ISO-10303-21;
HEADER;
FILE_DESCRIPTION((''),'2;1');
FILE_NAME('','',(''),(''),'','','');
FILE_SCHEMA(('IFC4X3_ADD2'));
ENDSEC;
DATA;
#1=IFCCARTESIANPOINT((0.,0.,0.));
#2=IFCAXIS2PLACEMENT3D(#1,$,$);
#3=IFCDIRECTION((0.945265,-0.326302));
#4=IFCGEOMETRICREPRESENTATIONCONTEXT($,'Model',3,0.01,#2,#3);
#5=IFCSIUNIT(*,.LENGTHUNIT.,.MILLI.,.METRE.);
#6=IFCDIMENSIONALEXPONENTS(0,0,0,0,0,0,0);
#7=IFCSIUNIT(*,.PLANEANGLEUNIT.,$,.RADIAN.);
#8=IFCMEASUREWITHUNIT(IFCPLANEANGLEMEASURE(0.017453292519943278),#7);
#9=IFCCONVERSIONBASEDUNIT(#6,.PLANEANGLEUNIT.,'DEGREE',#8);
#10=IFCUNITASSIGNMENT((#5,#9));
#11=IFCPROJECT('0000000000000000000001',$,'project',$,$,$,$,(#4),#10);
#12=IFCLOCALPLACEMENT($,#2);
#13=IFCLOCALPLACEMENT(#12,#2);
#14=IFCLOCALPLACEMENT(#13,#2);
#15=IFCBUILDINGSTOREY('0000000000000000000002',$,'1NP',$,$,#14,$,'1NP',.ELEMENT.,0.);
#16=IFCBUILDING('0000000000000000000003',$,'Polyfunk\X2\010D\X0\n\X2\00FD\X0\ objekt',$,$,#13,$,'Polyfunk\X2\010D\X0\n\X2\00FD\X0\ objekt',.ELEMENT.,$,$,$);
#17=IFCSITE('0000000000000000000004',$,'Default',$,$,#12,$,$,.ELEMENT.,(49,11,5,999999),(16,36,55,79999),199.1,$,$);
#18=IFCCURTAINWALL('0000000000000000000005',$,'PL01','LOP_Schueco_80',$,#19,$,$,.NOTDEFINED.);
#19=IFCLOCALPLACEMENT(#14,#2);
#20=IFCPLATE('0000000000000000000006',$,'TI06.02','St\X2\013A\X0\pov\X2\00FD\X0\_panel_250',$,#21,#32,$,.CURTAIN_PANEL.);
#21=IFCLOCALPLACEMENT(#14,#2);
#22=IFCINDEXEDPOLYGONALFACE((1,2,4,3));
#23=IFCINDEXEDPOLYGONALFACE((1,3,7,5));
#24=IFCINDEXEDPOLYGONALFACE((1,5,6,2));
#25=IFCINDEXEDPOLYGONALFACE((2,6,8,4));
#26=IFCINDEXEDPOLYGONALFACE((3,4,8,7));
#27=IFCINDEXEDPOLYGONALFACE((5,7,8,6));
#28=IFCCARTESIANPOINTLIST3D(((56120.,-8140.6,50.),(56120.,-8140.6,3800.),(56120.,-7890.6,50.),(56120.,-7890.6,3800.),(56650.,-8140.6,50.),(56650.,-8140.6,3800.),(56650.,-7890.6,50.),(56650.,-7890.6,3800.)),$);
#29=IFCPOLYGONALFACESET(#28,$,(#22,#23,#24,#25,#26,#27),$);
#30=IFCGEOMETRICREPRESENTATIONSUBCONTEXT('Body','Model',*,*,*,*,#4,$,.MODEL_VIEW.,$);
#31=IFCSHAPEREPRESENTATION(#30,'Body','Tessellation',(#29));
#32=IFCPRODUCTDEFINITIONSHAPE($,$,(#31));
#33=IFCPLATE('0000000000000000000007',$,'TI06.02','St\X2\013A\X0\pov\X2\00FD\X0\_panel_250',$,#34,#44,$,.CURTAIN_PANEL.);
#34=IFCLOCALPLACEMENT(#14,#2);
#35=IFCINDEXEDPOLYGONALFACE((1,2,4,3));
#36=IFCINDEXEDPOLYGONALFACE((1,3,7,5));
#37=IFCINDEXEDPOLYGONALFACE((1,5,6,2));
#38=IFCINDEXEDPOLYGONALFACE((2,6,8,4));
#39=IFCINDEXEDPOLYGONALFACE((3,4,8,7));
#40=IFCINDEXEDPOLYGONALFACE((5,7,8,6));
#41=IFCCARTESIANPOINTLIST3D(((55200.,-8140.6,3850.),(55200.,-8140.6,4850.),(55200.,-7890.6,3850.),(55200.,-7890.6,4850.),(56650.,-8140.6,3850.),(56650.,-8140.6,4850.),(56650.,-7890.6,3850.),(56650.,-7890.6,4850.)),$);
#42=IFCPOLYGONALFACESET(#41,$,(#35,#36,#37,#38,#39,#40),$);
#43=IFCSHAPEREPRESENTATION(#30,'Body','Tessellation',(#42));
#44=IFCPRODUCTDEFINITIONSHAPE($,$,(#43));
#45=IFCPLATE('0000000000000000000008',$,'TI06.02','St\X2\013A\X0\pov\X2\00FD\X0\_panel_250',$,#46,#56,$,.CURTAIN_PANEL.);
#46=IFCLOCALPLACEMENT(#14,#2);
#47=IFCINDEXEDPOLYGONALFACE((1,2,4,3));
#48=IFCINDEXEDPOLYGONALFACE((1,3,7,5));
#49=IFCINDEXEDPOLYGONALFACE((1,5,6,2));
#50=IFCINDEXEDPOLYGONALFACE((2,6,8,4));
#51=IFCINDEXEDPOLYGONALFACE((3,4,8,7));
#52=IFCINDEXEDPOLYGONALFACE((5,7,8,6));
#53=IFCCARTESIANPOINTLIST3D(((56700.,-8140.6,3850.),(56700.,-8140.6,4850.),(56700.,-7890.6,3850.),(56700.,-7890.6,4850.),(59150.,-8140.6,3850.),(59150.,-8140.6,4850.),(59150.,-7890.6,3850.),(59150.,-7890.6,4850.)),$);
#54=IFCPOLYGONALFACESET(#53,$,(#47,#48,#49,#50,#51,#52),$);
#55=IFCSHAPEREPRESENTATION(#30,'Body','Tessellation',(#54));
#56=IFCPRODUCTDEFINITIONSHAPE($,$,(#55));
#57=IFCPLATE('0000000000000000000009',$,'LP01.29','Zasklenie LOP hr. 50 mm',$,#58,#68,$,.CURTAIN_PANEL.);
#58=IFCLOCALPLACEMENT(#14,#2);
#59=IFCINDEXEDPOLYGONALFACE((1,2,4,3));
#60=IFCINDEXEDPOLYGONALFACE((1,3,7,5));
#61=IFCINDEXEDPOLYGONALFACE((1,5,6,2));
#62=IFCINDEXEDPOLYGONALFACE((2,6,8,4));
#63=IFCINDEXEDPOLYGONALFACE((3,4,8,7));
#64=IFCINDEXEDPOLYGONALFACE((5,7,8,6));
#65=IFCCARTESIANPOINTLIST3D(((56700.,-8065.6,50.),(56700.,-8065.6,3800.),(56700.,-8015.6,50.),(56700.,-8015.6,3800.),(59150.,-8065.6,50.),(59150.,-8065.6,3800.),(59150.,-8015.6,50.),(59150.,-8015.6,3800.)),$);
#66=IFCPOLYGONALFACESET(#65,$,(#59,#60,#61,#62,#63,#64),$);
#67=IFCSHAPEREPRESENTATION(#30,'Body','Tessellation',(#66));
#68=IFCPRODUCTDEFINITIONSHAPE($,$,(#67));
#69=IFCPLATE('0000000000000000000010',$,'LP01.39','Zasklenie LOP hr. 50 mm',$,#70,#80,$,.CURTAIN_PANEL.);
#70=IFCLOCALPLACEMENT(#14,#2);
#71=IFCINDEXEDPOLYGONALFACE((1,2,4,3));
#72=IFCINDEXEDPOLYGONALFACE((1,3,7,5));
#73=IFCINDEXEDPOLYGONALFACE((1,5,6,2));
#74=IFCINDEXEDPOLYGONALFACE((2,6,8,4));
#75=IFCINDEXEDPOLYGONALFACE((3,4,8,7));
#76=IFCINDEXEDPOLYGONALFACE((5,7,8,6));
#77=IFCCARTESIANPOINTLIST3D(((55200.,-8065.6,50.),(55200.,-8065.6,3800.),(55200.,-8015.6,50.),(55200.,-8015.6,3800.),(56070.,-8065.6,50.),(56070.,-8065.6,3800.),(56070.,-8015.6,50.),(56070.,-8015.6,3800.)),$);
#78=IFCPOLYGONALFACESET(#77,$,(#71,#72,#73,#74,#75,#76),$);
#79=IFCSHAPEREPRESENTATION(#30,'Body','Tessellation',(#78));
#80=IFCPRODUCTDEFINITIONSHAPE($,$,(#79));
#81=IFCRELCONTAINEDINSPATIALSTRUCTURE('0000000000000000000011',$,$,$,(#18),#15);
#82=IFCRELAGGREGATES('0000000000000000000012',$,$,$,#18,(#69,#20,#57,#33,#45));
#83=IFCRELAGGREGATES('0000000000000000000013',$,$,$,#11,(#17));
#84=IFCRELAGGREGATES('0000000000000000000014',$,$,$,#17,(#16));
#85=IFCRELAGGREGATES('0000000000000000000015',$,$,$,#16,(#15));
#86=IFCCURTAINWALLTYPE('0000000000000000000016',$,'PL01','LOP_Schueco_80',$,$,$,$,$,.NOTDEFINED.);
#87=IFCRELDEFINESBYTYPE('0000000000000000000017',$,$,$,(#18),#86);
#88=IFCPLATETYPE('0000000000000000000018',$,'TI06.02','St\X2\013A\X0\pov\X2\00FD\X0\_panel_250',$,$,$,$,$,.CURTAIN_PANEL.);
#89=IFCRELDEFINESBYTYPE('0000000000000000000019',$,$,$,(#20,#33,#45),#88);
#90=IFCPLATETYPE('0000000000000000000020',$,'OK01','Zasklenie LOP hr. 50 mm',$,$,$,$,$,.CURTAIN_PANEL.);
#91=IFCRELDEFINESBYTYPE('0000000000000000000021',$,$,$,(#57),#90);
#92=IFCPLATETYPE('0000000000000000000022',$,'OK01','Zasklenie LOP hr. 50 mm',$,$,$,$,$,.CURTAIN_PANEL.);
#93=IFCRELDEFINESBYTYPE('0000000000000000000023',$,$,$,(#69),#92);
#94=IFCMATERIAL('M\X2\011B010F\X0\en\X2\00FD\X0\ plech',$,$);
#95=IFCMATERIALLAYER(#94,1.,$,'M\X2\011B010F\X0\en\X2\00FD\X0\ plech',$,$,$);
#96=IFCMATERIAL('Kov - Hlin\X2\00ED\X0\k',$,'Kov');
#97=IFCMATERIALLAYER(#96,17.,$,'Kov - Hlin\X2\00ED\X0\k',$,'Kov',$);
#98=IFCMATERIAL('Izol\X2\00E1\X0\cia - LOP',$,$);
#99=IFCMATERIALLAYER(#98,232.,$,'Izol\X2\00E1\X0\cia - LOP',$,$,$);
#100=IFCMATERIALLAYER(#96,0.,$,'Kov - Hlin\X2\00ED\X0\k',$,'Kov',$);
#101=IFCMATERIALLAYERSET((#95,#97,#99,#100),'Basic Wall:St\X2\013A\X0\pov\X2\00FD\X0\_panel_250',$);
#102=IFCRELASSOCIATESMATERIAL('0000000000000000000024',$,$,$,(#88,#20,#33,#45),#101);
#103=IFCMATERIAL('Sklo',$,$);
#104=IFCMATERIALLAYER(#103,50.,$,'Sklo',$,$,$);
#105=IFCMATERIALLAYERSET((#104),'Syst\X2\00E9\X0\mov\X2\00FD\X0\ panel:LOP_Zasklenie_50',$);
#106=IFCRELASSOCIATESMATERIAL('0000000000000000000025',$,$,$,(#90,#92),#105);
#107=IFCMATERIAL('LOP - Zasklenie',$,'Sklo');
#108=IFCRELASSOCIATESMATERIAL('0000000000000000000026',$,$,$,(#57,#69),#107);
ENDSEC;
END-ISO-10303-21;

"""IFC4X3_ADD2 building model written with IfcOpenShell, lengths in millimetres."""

from ifc_helpers import new_model, entity, si_unit, converted_unit, direction, frame, frame_2d, origin, origin_2d_with_axis, place, context, subcontext, project, spatial, rectangle, extrude, source, transform, mapped, material, layer, layer_set, layer_usage, type_object, type_shapes, element, aggregate, save


model = new_model("IFC4X3_ADD2")

# Units and contexts
model_context = context("Model", 3, precision=0.01, world=origin(), true_north=direction((0.945265, -0.326302)))
body_context = subcontext(model_context, "Body", "Model", "MODEL_VIEW")
ifc_project = project(units=[si_unit("LENGTHUNIT", "METRE", prefix="MILLI"), converted_unit("PLANEANGLEUNIT", "DEGREE", entity("IfcPlaneAngleMeasure", 0.017453292519943278), si_unit("PLANEANGLEUNIT", "RADIAN"), dimensions=[0, 0, 0, 0, 0, 0, 0])], contexts=[model_context])

# Site, building, storey
site_placement = place(None, origin())
site = spatial("IfcSite", under=ifc_project, at=site_placement, Name="Default", CompositionType="ELEMENT", RefLatitude=(49, 11, 5, 999999), RefLongitude=(16, 36, 55, 79999), RefElevation=199.1)
building_placement = place(site_placement, origin())
building = spatial("IfcBuilding", under=site, at=building_placement, Name="Polyfunkčný objekt", LongName="Polyfunkčný objekt", CompositionType="ELEMENT")
storey_placement = place(building_placement, origin())
storey = spatial("IfcBuildingStorey", under=building, at=storey_placement, Name="1NP", LongName="1NP", CompositionType="ELEMENT", Elevation=0.0)

# Curtain wall, plates
curtain_wall_type = type_object("IfcCurtainWallType", Name="PL01", Description="LOP_Schueco_80", PredefinedType="NOTDEFINED")
curtain_wall_placement = place(storey_placement, origin())
curtain_wall = element("IfcCurtainWall", 1, at=curtain_wall_placement, inside=storey, type_object=curtain_wall_type, Name="PL01", Description="LOP_Schueco_80", PredefinedType="NOTDEFINED")
ifc_material_1 = material(Name="Měďený plech")
ifc_layer_1 = layer(ifc_material_1, 1.0, Name="Měďený plech")
ifc_material_2 = material(Name="Kov - Hliník", Category="Kov")
ifc_layer_2 = layer(ifc_material_2, 17.0, Name="Kov - Hliník", Category="Kov")
ifc_material_3 = material(Name="Izolácia - LOP")
ifc_layer_3 = layer(ifc_material_3, 232.0, Name="Izolácia - LOP")
ifc_layer_4 = layer(ifc_material_2, 0.0, Name="Kov - Hliník", Category="Kov")
ifc_layer_set_1 = layer_set([ifc_layer_1, ifc_layer_2, ifc_layer_3, ifc_layer_4], Name="Basic Wall:Stĺpový_panel_250")
ifc_layer_usage_1 = layer_usage(ifc_layer_set_1, "AXIS2", "POSITIVE", -125.0)
plate_type_1 = type_object("IfcPlateType", Name="TI06.02", Description="Stĺpový_panel_250", PredefinedType="CURTAIN_PANEL", material=ifc_layer_set_1)
plate_1_placement = place(storey_placement, frame((56120.0, -8015.6, 50.0)))
plate_1 = element("IfcPlate", 2, at=plate_1_placement, type_object=plate_type_1, material=ifc_layer_usage_1, Name="TI06.02", Description="Stĺpový_panel_250", PredefinedType="CURTAIN_PANEL", context=body_context, shape_type="SweptSolid", body=[
    extrude(rectangle(XDim=250.0, YDim=530.0, at=frame_2d((0.0, 0.0), x_axis=(1.0, 0.0))), frame((265.0, 0.0, 0.0), z_axis=(0.0, 0.0, 1.0), x_axis=(0.0, 1.0, 0.0)), (0.0, 0.0, 1.0), 3750.0),
])
ifc_layer_usage_2 = layer_usage(ifc_layer_set_1, "AXIS2", "POSITIVE", -125.0)
plate_2_placement = place(storey_placement, frame((55200.0, -8015.6, 3850.0)))
plate_2 = element("IfcPlate", 3, at=plate_2_placement, type_object=plate_type_1, material=ifc_layer_usage_2, Name="TI06.02", Description="Stĺpový_panel_250", PredefinedType="CURTAIN_PANEL", context=body_context, shape_type="SweptSolid", body=[
    extrude(rectangle(XDim=250.0, YDim=1450.0, at=frame_2d((0.0, 0.0), x_axis=(1.0, 0.0))), frame((725.0, 0.0, 0.0), z_axis=(0.0, 0.0, 1.0), x_axis=(0.0, 1.0, 0.0)), (0.0, 0.0, 1.0), 1000.0),
])
ifc_layer_usage_3 = layer_usage(ifc_layer_set_1, "AXIS2", "POSITIVE", -125.0)
plate_3_placement = place(storey_placement, frame((56700.0, -8015.6, 3850.0)))
plate_3 = element("IfcPlate", 4, at=plate_3_placement, type_object=plate_type_1, material=ifc_layer_usage_3, Name="TI06.02", Description="Stĺpový_panel_250", PredefinedType="CURTAIN_PANEL", context=body_context, shape_type="SweptSolid", body=[
    extrude(rectangle(XDim=250.0, YDim=2450.0, at=origin_2d_with_axis()), frame((1225.0, 0.0, 0.0), z_axis=(0.0, 0.0, 1.0), x_axis=(0.0, 1.0, 0.0)), (0.0, 0.0, 1.0), 1000.0),
])
ifc_material_4 = material(Name="LOP - Zasklenie", Category="Sklo")
ifc_material_5 = material(Name="Sklo")
ifc_layer_5 = layer(ifc_material_5, 50.0, Name="Sklo")
ifc_layer_set_2 = layer_set([ifc_layer_5], Name="Systémový panel:LOP_Zasklenie_50")
plate_type_2 = type_object("IfcPlateType", Name="OK01", Description="Zasklenie LOP hr. 50 mm", PredefinedType="CURTAIN_PANEL", material=ifc_layer_set_2)
shared_shape_1 = source(origin(), body_context, "Body", "SweptSolid", [
    extrude(rectangle(XDim=3750.0, YDim=2450.0, at=frame_2d((-331.2, 0.0), x_axis=(1.0, 0.0))), frame((0.0, -50.0, 2206.2), z_axis=(0.0, 1.0, 0.0), x_axis=(0.0, 0.0, 1.0)), (0.0, 0.0, 1.0), 50.0),
])
type_shapes(plate_type_2, [shared_shape_1])
plate_4_placement = place(curtain_wall_placement, frame((57925.0, -8015.6, 50.0)))
plate_4 = element("IfcPlate", 5, at=plate_4_placement, type_object=plate_type_2, material=ifc_material_4, Name="LP01.29", Description="Zasklenie LOP hr. 50 mm", PredefinedType="CURTAIN_PANEL", context=body_context, shape_type="MappedRepresentation", body=[
    mapped(shared_shape_1, transform((0.0, 0.0, 0.0), scale=1.0)),
])
plate_type_3 = type_object("IfcPlateType", Name="OK01", Description="Zasklenie LOP hr. 50 mm", PredefinedType="CURTAIN_PANEL", material=ifc_layer_set_2)
shared_shape_2 = source(origin(), body_context, "Body", "SweptSolid", [
    extrude(rectangle(XDim=3750.0, YDim=870.0, at=frame_2d((-331.2, 0.0), x_axis=(1.0, 0.0))), frame((0.0, -50.0, 2206.2), z_axis=(0.0, 1.0, 0.0), x_axis=(0.0, 0.0, 1.0)), (0.0, 0.0, 1.0), 50.0),
])
type_shapes(plate_type_3, [shared_shape_2])
plate_5_placement = place(curtain_wall_placement, frame((55635.0, -8015.6, 50.0)))
plate_5 = element("IfcPlate", 6, at=plate_5_placement, type_object=plate_type_3, material=ifc_material_4, Name="LP01.39", Description="Zasklenie LOP hr. 50 mm", PredefinedType="CURTAIN_PANEL", context=body_context, shape_type="MappedRepresentation", body=[
    mapped(shared_shape_2, transform((0.0, 0.0, 0.0), scale=1.0)),
])
aggregate(curtain_wall, [plate_5, plate_1, plate_4, plate_2, plate_3])

save(model, "model.ifc")
